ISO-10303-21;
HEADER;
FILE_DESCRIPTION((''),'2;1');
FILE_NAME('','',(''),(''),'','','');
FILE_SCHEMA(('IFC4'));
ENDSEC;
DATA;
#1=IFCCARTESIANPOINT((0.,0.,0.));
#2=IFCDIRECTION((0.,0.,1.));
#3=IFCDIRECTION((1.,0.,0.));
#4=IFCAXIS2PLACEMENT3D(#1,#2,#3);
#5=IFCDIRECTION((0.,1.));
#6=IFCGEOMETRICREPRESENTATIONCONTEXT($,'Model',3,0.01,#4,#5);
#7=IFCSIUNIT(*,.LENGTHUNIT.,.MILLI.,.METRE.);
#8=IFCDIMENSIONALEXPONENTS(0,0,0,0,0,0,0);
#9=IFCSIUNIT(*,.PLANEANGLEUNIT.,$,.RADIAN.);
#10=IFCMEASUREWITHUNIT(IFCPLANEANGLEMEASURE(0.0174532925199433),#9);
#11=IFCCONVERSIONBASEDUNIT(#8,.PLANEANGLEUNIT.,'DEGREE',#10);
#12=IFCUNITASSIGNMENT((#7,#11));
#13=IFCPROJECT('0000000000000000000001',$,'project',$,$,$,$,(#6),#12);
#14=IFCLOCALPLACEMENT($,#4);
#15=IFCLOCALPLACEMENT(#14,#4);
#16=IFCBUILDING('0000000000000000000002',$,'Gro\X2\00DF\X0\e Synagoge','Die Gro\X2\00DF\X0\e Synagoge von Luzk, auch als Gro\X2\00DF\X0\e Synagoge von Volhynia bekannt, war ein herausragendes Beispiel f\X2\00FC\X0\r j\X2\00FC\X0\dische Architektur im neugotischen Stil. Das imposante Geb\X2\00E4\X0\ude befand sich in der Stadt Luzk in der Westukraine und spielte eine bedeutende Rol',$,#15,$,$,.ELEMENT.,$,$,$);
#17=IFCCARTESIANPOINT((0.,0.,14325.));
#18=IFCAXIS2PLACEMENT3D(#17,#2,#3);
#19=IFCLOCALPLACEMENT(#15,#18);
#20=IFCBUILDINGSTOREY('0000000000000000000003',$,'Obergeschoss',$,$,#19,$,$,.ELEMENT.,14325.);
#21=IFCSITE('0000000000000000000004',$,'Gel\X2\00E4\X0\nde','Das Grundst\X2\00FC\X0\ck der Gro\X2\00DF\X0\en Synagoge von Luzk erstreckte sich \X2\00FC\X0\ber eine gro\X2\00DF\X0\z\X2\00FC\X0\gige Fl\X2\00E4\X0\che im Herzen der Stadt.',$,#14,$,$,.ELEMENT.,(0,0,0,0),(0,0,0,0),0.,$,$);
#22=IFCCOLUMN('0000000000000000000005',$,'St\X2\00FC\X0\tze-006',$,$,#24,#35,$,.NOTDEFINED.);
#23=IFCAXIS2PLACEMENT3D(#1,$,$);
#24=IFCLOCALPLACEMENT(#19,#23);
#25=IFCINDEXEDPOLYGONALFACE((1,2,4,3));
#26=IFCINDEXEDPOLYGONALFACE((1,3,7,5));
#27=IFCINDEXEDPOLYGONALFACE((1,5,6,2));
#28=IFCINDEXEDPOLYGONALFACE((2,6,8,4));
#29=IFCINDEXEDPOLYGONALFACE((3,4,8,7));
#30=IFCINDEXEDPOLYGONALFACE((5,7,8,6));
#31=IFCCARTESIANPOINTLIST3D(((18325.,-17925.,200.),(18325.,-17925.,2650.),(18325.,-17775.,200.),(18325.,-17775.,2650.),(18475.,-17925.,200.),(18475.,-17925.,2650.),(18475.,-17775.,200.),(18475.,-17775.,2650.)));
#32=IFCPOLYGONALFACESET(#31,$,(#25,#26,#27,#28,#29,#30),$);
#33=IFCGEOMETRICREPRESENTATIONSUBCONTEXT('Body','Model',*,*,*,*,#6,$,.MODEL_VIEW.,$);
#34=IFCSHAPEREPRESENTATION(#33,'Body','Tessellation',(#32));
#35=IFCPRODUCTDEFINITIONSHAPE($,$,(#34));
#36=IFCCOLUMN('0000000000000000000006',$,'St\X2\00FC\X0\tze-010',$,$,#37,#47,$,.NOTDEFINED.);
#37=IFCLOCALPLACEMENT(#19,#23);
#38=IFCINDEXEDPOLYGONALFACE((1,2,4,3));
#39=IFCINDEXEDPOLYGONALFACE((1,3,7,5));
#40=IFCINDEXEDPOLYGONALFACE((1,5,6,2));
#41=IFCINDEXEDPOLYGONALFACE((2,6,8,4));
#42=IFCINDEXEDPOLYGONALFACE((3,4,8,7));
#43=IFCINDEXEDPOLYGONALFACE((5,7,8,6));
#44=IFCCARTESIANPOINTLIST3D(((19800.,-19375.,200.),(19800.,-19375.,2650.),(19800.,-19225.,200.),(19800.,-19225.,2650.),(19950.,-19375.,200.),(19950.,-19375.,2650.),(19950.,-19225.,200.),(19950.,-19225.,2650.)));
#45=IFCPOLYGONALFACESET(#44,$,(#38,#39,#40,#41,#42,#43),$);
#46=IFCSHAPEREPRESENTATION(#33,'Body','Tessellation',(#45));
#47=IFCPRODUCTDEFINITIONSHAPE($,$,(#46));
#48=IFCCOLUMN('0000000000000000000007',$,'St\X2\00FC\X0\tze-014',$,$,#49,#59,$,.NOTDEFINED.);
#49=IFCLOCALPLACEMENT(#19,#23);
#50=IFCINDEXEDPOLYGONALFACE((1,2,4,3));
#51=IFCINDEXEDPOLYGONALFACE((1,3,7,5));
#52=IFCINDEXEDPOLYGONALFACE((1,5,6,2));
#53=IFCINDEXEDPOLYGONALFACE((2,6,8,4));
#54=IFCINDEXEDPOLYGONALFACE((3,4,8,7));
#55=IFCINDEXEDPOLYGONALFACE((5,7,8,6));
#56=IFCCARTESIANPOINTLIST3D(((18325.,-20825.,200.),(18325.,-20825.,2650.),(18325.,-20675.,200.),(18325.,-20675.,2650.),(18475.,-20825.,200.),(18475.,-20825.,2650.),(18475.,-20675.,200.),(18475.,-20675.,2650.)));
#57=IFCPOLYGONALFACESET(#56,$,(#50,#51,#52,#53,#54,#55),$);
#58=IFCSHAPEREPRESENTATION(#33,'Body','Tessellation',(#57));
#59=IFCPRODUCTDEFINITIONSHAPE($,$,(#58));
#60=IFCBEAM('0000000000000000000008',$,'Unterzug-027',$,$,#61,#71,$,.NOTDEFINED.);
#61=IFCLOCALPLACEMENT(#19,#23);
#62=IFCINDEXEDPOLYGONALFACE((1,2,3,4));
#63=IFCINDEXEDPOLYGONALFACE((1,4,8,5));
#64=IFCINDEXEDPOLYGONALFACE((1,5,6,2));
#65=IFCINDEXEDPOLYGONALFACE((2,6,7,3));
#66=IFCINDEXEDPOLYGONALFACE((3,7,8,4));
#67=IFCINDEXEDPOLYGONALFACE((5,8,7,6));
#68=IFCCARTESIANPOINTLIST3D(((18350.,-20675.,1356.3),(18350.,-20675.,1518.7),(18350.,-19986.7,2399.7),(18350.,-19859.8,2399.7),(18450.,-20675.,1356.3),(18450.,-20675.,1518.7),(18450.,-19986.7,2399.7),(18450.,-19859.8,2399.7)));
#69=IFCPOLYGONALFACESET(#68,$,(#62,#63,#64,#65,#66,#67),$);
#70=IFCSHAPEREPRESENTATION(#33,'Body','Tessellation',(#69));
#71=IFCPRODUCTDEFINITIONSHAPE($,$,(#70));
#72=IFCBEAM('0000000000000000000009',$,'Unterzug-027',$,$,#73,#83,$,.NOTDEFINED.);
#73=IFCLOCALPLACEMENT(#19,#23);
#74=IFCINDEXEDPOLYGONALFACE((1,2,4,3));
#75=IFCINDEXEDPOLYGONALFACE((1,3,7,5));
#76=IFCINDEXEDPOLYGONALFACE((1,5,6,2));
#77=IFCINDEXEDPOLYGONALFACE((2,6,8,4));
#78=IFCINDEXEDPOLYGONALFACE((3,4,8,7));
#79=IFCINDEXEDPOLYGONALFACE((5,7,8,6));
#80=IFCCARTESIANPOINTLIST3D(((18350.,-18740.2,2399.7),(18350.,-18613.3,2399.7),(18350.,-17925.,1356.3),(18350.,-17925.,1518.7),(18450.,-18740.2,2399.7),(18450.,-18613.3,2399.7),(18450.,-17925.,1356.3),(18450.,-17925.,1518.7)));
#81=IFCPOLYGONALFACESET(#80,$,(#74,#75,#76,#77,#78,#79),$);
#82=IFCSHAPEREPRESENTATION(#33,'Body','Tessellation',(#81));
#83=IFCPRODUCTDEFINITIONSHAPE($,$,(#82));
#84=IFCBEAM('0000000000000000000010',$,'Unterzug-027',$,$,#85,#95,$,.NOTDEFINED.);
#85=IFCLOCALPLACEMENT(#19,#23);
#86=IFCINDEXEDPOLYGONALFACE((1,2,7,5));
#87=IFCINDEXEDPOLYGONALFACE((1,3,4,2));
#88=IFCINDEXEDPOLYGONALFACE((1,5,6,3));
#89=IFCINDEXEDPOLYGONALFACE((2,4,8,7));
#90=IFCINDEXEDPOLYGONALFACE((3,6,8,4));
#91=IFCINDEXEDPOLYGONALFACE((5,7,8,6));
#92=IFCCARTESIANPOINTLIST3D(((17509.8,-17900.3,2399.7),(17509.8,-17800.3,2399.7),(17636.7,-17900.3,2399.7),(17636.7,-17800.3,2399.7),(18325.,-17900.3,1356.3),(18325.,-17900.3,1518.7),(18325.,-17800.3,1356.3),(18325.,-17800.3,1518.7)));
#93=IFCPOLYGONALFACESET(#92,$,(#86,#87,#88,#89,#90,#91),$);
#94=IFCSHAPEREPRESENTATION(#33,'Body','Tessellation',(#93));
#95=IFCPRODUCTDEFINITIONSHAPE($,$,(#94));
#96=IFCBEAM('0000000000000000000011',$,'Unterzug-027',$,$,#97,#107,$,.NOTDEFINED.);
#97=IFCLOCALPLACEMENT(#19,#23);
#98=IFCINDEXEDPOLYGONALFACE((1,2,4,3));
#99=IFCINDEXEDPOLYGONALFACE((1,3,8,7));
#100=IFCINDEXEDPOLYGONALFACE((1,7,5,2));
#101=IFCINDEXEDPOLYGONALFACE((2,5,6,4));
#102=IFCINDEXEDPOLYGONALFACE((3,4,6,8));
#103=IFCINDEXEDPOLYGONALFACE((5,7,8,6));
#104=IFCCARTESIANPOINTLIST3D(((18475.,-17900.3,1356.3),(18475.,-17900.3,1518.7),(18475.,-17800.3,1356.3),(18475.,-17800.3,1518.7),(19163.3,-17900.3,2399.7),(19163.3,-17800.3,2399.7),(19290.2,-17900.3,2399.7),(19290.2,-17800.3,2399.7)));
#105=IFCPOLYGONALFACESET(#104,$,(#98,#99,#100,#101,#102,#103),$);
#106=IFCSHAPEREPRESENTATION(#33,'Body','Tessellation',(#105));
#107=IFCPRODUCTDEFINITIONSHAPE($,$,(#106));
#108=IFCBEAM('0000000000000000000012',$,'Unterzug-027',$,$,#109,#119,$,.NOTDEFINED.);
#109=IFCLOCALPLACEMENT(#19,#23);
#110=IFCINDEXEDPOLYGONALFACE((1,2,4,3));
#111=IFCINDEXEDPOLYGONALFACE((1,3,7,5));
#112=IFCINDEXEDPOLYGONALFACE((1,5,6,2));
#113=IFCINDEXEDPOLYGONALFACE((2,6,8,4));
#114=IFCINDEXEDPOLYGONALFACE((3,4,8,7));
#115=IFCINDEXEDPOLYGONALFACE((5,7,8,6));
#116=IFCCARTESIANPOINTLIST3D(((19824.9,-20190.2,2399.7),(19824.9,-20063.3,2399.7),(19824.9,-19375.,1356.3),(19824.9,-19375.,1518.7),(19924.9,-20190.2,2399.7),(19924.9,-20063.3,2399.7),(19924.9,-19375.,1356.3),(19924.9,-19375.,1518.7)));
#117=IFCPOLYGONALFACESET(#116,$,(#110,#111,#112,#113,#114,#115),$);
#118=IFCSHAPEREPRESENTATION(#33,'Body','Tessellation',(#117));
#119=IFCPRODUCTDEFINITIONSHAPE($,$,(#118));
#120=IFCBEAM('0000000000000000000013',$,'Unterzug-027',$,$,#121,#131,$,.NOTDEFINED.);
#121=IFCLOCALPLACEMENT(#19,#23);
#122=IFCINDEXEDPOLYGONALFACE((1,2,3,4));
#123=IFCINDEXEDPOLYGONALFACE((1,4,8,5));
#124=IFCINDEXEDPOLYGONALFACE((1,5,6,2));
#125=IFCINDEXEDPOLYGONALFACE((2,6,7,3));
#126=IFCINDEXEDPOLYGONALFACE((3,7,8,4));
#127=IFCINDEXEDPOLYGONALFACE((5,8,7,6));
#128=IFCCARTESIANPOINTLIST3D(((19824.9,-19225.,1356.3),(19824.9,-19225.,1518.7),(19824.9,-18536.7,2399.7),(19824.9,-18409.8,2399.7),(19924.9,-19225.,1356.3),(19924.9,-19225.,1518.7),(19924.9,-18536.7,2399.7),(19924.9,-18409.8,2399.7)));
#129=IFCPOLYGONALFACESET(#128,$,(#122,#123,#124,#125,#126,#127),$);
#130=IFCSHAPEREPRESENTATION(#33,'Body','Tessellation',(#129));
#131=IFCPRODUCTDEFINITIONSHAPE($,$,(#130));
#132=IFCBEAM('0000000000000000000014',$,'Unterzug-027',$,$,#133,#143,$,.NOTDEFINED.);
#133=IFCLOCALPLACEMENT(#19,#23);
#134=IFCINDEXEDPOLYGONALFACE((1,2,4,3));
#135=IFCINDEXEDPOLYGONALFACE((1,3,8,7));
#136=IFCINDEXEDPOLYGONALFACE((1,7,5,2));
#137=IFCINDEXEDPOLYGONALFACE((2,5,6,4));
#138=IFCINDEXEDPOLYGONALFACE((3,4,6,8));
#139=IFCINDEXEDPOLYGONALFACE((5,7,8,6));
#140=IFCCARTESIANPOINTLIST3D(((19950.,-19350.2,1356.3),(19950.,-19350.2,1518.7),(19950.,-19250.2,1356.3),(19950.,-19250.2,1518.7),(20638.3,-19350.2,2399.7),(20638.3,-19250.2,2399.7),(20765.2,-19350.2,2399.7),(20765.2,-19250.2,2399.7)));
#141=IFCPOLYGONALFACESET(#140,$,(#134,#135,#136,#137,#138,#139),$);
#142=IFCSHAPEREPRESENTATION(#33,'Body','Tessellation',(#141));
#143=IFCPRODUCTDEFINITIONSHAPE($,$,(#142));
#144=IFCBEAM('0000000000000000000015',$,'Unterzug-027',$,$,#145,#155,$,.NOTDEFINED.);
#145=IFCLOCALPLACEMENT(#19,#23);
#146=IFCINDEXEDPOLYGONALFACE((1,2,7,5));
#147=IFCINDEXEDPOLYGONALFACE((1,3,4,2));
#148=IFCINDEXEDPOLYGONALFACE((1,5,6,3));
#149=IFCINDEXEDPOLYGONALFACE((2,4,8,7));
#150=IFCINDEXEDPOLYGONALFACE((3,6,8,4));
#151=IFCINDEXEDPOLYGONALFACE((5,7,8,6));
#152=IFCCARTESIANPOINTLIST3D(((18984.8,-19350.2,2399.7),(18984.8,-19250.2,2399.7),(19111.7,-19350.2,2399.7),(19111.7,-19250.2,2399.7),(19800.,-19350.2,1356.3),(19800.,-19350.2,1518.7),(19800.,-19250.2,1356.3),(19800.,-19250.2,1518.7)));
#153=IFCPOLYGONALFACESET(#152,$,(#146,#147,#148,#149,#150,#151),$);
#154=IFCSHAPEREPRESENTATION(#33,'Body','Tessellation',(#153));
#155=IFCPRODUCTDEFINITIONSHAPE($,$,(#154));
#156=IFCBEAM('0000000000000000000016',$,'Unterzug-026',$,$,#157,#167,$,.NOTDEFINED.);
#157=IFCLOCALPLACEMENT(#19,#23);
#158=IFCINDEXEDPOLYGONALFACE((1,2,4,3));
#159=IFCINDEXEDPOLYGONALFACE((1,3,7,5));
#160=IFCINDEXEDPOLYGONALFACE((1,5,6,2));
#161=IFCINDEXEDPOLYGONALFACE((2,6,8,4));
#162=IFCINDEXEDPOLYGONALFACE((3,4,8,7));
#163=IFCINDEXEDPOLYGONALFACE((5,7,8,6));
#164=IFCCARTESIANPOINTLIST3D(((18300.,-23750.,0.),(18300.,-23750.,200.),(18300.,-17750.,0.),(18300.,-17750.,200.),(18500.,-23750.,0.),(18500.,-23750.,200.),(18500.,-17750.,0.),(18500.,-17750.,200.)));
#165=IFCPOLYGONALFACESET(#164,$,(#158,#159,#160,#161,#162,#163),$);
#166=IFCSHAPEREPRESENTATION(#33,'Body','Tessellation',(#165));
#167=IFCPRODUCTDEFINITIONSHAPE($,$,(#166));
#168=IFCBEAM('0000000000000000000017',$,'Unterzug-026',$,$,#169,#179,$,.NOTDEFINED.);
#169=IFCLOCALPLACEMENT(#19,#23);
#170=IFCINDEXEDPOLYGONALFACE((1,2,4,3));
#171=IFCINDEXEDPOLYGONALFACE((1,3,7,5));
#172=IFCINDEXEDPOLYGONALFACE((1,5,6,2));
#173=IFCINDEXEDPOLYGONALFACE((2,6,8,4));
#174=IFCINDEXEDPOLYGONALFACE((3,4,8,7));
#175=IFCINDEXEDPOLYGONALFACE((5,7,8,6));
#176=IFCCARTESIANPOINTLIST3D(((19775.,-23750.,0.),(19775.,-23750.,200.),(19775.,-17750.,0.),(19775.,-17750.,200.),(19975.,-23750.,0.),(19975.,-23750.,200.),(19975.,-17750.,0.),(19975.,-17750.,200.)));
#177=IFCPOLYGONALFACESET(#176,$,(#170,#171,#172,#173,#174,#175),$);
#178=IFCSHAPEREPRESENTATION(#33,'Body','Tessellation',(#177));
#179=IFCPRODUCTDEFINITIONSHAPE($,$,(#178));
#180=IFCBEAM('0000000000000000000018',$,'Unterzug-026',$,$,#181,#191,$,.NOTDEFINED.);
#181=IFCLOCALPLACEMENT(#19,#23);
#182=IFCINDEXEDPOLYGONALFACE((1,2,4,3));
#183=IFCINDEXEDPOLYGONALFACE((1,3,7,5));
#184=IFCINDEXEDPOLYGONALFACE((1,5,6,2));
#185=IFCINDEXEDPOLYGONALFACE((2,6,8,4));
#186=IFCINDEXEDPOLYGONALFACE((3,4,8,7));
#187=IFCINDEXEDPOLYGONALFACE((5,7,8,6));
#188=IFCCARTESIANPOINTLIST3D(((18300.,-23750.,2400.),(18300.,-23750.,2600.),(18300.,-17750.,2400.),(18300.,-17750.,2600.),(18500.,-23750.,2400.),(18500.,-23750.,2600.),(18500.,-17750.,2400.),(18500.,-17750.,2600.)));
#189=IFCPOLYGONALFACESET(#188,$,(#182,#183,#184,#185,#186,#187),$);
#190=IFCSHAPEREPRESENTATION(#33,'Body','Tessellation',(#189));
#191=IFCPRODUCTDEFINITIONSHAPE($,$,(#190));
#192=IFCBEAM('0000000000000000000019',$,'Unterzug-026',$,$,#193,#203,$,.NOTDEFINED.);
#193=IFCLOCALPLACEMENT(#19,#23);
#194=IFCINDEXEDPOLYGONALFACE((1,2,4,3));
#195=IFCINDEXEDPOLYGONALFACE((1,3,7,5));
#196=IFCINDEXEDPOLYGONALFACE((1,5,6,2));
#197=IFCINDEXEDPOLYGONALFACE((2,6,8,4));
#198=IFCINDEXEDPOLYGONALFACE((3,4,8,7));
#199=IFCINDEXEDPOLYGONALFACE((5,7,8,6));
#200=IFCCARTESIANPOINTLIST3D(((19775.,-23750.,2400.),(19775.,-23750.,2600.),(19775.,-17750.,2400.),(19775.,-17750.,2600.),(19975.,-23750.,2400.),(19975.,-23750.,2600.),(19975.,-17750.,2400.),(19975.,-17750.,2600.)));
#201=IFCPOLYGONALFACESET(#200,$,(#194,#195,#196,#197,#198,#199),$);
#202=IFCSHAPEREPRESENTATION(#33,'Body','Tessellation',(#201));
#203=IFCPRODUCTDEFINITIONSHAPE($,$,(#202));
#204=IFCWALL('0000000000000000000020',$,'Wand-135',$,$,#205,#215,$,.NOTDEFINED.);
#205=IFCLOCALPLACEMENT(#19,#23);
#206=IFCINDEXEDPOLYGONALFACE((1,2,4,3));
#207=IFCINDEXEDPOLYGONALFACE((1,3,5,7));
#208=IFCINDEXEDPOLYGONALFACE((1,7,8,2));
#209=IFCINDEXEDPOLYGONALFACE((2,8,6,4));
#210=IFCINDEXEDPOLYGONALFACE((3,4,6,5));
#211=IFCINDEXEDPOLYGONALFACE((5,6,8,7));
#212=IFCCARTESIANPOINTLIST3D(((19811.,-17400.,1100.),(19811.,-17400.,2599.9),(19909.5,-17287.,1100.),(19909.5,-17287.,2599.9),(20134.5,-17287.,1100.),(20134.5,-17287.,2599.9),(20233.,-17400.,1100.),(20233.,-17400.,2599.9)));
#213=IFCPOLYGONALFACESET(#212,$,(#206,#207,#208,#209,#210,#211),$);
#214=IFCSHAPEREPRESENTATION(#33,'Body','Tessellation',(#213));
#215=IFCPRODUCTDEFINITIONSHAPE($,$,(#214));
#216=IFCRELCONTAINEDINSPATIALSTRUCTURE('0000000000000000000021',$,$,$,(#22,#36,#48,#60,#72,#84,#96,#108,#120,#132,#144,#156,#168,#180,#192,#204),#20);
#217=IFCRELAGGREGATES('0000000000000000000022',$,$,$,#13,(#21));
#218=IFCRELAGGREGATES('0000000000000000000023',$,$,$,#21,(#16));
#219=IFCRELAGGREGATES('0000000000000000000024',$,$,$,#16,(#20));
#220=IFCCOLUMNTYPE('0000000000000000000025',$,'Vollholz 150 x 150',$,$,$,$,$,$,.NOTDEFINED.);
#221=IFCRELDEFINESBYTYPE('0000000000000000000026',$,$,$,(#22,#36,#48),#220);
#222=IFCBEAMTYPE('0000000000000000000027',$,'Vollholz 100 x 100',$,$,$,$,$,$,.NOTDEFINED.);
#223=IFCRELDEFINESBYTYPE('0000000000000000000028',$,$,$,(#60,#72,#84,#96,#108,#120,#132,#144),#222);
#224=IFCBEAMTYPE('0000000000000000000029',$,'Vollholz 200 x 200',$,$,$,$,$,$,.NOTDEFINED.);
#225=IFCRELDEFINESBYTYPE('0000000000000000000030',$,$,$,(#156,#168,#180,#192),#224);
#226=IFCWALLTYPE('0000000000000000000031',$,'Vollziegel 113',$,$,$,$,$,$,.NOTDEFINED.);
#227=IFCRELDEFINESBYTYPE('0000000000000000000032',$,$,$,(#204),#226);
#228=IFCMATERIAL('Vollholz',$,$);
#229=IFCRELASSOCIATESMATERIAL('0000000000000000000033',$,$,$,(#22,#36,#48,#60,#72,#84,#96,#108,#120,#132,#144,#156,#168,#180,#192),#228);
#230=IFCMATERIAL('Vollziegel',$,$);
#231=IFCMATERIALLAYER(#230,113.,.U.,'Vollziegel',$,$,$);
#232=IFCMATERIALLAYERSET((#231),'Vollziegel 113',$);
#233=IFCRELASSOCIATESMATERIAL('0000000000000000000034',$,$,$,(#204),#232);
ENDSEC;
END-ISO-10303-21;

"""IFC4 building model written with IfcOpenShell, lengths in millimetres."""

from ifc_helpers import new_model, entity, si_unit, converted_unit, direction, frame, frame_2d, origin_with_axes, origin_2d_with_axis, place, context, subcontext, project, spatial, line, indexed_curve, rectangle, outline, extrude, clip, halfspace, material, layer, layer_set, layer_usage, type_object, element, save


model = new_model("IFC4")

# Units and contexts
model_context = context("Model", 3, precision=0.01, world=origin_with_axes(), true_north=direction((0.0, 1.0)))
body_context = subcontext(model_context, "Body", "Model", "MODEL_VIEW")
ifc_project = project(units=[si_unit("LENGTHUNIT", "METRE", prefix="MILLI"), converted_unit("PLANEANGLEUNIT", "DEGREE", entity("IfcPlaneAngleMeasure", 0.0174532925199433), si_unit("PLANEANGLEUNIT", "RADIAN"), dimensions=[0, 0, 0, 0, 0, 0, 0])], contexts=[model_context])

# Site, building, storey
site_placement = place(None, origin_with_axes())
site = spatial("IfcSite", under=ifc_project, at=site_placement, Name="Gelände", Description="Das Grundstück der Großen Synagoge von Luzk erstreckte sich über eine großzügige Fläche im Herzen der Stadt.", CompositionType="ELEMENT", RefLatitude=(0, 0, 0, 0), RefLongitude=(0, 0, 0, 0), RefElevation=0.0)
building_placement = place(site_placement, origin_with_axes())
building = spatial("IfcBuilding", under=site, at=building_placement, Name="Große Synagoge", Description="Die Große Synagoge von Luzk, auch als Große Synagoge von Volhynia bekannt, war ein herausragendes Beispiel für jüdische Architektur im neugotischen Stil. Das imposante Gebäude befand sich in der Stadt Luzk in der Westukraine und spielte eine bedeutende Rol", CompositionType="ELEMENT")
storey_placement = place(building_placement, frame((0.0, 0.0, 14325.0), z_axis=(0.0, 0.0, 1.0), x_axis=(1.0, 0.0, 0.0)))
storey = spatial("IfcBuildingStorey", under=building, at=storey_placement, Name="Obergeschoss", CompositionType="ELEMENT", Elevation=14325.0)

# Columns
ifc_material_1 = material(Name="Vollholz")
column_type = type_object("IfcColumnType", Name="Vollholz 150 x 150", PredefinedType="NOTDEFINED")
for number, where, z_axis, x_axis, name in (
    (1, (18400.0, -17850.0, 200.0), (0.0, 0.0, 1.0), (1.0, 0.0, 0.0), "Stütze-006"),
    (2, (19875.0, -19300.0, 200.0), (0.0, 0.0, 1.0), (1.0, 0.0, 0.0), "Stütze-010"),
    (3, (18400.0, -20750.0, 200.0), (0.0, 0.0, 1.0), (1.0, 0.0, 0.0), "Stütze-014"),
):
    element("IfcColumn", number, at=place(storey_placement, frame(where, z_axis=z_axis, x_axis=x_axis)), inside=storey, type_object=column_type, material=ifc_material_1, Name=name, PredefinedType="NOTDEFINED", context=body_context, shape_type="SweptSolid", body=[
        extrude(rectangle(XDim=150.0, YDim=150.0, at=origin_2d_with_axis()), origin_with_axes(), (0.0, 0.0, 1.0), 2450.0),
    ])

# Beams
beam_type_1 = type_object("IfcBeamType", Name="Vollholz 100 x 100", PredefinedType="NOTDEFINED")
for number, where, z_axis, x_axis, name in (
    (4, (18400.0, -20675.0, 1518.7), (0.0, 0.0, 1.0), (1.0, 0.0, 0.0), "Unterzug-027"),
    (5, (18400.0, -17925.0, 1518.7), (0.0, 0.0, 1.0), (-1.0, 0.0, 0.0), "Unterzug-027"),
):
    element("IfcBeam", number, at=place(storey_placement, frame(where, z_axis=z_axis, x_axis=x_axis)), inside=storey, type_object=beam_type_1, material=ifc_material_1, Name=name, PredefinedType="NOTDEFINED", context=body_context, shape_type="Clipping", body=[
        clip(clip(extrude(rectangle(XDim=100.0, YDim=100.0, at=frame_2d((-50.0, 0.0), x_axis=(1.0, 0.0))), frame((0.0, -111.4, -142.6), z_axis=(0.0, 0.615661, 0.788011), x_axis=(0.0, -0.788011, 0.615661)), (0.0, 0.0, 1.0), 1409.5), halfspace(frame((0.0, 0.0, 0.0), z_axis=(0.0, 1.0, 0.0), x_axis=(0.0, 0.0, 1.0)), True)), halfspace(frame((0.0, 0.0, 881.0), z_axis=(0.0, 0.0, -1.0), x_axis=(0.0, 1.0, 0.0)), True)),
    ])
for number, where, z_axis, x_axis, name in (
    (6, (18325.0, -17850.3, 1518.7), (0.0, 0.0, 1.0), (0.0, 1.0, 0.0), "Unterzug-027"),
    (7, (18475.0, -17850.3, 1518.7), (0.0, 0.0, 1.0), (0.0, -1.0, 0.0), "Unterzug-027"),
    (8, (19874.9, -19375.0, 1518.7), (0.0, 0.0, 1.0), (-1.0, 0.0, 0.0), "Unterzug-027"),
    (9, (19874.9, -19225.0, 1518.7), (0.0, 0.0, 1.0), (1.0, 0.0, 0.0), "Unterzug-027"),
):
    element("IfcBeam", number, at=place(storey_placement, frame(where, z_axis=z_axis, x_axis=x_axis)), inside=storey, type_object=beam_type_1, material=ifc_material_1, Name=name, PredefinedType="NOTDEFINED", context=body_context, shape_type="Clipping", body=[
        clip(clip(extrude(rectangle(XDim=100.0, YDim=100.0, at=frame_2d((-50.0, 0.0), x_axis=(1.0, 0.0))), frame((0.0, -111.4, -142.6), z_axis=(0.0, 0.615661, 0.788011), x_axis=(0.0, -0.788011, 0.615661)), (0.0, 0.0, 1.0), 1409.5), halfspace(frame((0.0, 0.0, 0.0), z_axis=(0.0, 1.0, 0.0), x_axis=(0.0, 0.0, 1.0)), True)), halfspace(frame((0.0, 0.0, 881.0), z_axis=(0.0, 0.0, -1.0), x_axis=(0.0, 1.0, 0.0)), True)),
    ])
for number, where, z_axis, x_axis, name in (
    (10, (19950.0, -19300.2, 1518.7), (0.0, 0.0, 1.0), (0.0, -1.0, 0.0), "Unterzug-027"),
    (11, (19800.0, -19300.2, 1518.7), (0.0, 0.0, 1.0), (0.0, 1.0, 0.0), "Unterzug-027"),
):
    element("IfcBeam", number, at=place(storey_placement, frame(where, z_axis=z_axis, x_axis=x_axis)), inside=storey, type_object=beam_type_1, material=ifc_material_1, Name=name, PredefinedType="NOTDEFINED", context=body_context, shape_type="Clipping", body=[
        clip(clip(extrude(rectangle(XDim=100.0, YDim=100.0, at=frame_2d((-50.0, 0.0), x_axis=(1.0, 0.0))), frame((0.0, -111.4, -142.6), z_axis=(0.0, 0.615661, 0.788011), x_axis=(0.0, -0.788011, 0.615661)), (0.0, 0.0, 1.0), 1409.5), halfspace(frame((0.0, 0.0, 0.0), z_axis=(0.0, 1.0, 0.0), x_axis=(0.0, 0.0, 1.0)), True)), halfspace(frame((0.0, 0.0, 881.0), z_axis=(0.0, 0.0, -1.0), x_axis=(0.0, 1.0, 0.0)), True)),
    ])
beam_type_2 = type_object("IfcBeamType", Name="Vollholz 200 x 200", PredefinedType="NOTDEFINED")
for number, where, z_axis, x_axis, name in (
    (12, (18400.0, -17750.0, 200.0), (0.0, 0.0, 1.0), (-1.0, 0.0, 0.0), "Unterzug-026"),
    (13, (19875.0, -17750.0, 200.0), (0.0, 0.0, 1.0), (-1.0, 0.0, 0.0), "Unterzug-026"),
    (14, (18400.0, -17750.0, 2600.0), (0.0, 0.0, 1.0), (-1.0, 0.0, 0.0), "Unterzug-026"),
    (15, (19875.0, -17750.0, 2600.0), (0.0, 0.0, 1.0), (-1.0, 0.0, 0.0), "Unterzug-026"),
):
    element("IfcBeam", number, at=place(storey_placement, frame(where, z_axis=z_axis, x_axis=x_axis)), inside=storey, type_object=beam_type_2, material=ifc_material_1, Name=name, PredefinedType="NOTDEFINED", context=body_context, shape_type="SweptSolid", body=[
        extrude(rectangle(XDim=200.0, YDim=200.0, at=frame_2d((-100.0, 0.0), x_axis=(1.0, 0.0))), frame((0.0, 0.0, 0.0), z_axis=(0.0, 1.0, 0.0), x_axis=(0.0, 0.0, 1.0)), (0.0, 0.0, 1.0), 6000.0),
    ])

# Wall
ifc_material_2 = material(Name="Vollziegel")
ifc_layer = layer(ifc_material_2, 113.0, ventilated="UNKNOWN", Name="Vollziegel")
ifc_layer_set = layer_set([ifc_layer], Name="Vollziegel 113")
ifc_layer_usage = layer_usage(ifc_layer_set, "AXIS2", "NEGATIVE", 113.0)
wall_type_1 = type_object("IfcWallType", Name="Vollziegel 113", PredefinedType="NOTDEFINED")
wall_1_placement = place(storey_placement, frame((19909.5, -17400.0, 1100.0), z_axis=(0.0, 0.0, 1.0), x_axis=(1.0, 0.0, 0.0)))
element("IfcWall", 16, at=wall_1_placement, inside=storey, type_object=wall_type_1, material=ifc_layer_usage, Name="Wand-135", PredefinedType="NOTDEFINED", context=body_context, shape_type="SweptSolid", body=[
    extrude(outline(indexed_curve([(-98.5, 0.0), (323.5, 0.0), (225.0, 113.0), (0.0, 113.0)], segments=[line(1, 2, 3, 4, 1)])), origin_with_axes(), (0.0, 0.0, 1.0), 1499.9),
])

save(model, "model.ifc")
